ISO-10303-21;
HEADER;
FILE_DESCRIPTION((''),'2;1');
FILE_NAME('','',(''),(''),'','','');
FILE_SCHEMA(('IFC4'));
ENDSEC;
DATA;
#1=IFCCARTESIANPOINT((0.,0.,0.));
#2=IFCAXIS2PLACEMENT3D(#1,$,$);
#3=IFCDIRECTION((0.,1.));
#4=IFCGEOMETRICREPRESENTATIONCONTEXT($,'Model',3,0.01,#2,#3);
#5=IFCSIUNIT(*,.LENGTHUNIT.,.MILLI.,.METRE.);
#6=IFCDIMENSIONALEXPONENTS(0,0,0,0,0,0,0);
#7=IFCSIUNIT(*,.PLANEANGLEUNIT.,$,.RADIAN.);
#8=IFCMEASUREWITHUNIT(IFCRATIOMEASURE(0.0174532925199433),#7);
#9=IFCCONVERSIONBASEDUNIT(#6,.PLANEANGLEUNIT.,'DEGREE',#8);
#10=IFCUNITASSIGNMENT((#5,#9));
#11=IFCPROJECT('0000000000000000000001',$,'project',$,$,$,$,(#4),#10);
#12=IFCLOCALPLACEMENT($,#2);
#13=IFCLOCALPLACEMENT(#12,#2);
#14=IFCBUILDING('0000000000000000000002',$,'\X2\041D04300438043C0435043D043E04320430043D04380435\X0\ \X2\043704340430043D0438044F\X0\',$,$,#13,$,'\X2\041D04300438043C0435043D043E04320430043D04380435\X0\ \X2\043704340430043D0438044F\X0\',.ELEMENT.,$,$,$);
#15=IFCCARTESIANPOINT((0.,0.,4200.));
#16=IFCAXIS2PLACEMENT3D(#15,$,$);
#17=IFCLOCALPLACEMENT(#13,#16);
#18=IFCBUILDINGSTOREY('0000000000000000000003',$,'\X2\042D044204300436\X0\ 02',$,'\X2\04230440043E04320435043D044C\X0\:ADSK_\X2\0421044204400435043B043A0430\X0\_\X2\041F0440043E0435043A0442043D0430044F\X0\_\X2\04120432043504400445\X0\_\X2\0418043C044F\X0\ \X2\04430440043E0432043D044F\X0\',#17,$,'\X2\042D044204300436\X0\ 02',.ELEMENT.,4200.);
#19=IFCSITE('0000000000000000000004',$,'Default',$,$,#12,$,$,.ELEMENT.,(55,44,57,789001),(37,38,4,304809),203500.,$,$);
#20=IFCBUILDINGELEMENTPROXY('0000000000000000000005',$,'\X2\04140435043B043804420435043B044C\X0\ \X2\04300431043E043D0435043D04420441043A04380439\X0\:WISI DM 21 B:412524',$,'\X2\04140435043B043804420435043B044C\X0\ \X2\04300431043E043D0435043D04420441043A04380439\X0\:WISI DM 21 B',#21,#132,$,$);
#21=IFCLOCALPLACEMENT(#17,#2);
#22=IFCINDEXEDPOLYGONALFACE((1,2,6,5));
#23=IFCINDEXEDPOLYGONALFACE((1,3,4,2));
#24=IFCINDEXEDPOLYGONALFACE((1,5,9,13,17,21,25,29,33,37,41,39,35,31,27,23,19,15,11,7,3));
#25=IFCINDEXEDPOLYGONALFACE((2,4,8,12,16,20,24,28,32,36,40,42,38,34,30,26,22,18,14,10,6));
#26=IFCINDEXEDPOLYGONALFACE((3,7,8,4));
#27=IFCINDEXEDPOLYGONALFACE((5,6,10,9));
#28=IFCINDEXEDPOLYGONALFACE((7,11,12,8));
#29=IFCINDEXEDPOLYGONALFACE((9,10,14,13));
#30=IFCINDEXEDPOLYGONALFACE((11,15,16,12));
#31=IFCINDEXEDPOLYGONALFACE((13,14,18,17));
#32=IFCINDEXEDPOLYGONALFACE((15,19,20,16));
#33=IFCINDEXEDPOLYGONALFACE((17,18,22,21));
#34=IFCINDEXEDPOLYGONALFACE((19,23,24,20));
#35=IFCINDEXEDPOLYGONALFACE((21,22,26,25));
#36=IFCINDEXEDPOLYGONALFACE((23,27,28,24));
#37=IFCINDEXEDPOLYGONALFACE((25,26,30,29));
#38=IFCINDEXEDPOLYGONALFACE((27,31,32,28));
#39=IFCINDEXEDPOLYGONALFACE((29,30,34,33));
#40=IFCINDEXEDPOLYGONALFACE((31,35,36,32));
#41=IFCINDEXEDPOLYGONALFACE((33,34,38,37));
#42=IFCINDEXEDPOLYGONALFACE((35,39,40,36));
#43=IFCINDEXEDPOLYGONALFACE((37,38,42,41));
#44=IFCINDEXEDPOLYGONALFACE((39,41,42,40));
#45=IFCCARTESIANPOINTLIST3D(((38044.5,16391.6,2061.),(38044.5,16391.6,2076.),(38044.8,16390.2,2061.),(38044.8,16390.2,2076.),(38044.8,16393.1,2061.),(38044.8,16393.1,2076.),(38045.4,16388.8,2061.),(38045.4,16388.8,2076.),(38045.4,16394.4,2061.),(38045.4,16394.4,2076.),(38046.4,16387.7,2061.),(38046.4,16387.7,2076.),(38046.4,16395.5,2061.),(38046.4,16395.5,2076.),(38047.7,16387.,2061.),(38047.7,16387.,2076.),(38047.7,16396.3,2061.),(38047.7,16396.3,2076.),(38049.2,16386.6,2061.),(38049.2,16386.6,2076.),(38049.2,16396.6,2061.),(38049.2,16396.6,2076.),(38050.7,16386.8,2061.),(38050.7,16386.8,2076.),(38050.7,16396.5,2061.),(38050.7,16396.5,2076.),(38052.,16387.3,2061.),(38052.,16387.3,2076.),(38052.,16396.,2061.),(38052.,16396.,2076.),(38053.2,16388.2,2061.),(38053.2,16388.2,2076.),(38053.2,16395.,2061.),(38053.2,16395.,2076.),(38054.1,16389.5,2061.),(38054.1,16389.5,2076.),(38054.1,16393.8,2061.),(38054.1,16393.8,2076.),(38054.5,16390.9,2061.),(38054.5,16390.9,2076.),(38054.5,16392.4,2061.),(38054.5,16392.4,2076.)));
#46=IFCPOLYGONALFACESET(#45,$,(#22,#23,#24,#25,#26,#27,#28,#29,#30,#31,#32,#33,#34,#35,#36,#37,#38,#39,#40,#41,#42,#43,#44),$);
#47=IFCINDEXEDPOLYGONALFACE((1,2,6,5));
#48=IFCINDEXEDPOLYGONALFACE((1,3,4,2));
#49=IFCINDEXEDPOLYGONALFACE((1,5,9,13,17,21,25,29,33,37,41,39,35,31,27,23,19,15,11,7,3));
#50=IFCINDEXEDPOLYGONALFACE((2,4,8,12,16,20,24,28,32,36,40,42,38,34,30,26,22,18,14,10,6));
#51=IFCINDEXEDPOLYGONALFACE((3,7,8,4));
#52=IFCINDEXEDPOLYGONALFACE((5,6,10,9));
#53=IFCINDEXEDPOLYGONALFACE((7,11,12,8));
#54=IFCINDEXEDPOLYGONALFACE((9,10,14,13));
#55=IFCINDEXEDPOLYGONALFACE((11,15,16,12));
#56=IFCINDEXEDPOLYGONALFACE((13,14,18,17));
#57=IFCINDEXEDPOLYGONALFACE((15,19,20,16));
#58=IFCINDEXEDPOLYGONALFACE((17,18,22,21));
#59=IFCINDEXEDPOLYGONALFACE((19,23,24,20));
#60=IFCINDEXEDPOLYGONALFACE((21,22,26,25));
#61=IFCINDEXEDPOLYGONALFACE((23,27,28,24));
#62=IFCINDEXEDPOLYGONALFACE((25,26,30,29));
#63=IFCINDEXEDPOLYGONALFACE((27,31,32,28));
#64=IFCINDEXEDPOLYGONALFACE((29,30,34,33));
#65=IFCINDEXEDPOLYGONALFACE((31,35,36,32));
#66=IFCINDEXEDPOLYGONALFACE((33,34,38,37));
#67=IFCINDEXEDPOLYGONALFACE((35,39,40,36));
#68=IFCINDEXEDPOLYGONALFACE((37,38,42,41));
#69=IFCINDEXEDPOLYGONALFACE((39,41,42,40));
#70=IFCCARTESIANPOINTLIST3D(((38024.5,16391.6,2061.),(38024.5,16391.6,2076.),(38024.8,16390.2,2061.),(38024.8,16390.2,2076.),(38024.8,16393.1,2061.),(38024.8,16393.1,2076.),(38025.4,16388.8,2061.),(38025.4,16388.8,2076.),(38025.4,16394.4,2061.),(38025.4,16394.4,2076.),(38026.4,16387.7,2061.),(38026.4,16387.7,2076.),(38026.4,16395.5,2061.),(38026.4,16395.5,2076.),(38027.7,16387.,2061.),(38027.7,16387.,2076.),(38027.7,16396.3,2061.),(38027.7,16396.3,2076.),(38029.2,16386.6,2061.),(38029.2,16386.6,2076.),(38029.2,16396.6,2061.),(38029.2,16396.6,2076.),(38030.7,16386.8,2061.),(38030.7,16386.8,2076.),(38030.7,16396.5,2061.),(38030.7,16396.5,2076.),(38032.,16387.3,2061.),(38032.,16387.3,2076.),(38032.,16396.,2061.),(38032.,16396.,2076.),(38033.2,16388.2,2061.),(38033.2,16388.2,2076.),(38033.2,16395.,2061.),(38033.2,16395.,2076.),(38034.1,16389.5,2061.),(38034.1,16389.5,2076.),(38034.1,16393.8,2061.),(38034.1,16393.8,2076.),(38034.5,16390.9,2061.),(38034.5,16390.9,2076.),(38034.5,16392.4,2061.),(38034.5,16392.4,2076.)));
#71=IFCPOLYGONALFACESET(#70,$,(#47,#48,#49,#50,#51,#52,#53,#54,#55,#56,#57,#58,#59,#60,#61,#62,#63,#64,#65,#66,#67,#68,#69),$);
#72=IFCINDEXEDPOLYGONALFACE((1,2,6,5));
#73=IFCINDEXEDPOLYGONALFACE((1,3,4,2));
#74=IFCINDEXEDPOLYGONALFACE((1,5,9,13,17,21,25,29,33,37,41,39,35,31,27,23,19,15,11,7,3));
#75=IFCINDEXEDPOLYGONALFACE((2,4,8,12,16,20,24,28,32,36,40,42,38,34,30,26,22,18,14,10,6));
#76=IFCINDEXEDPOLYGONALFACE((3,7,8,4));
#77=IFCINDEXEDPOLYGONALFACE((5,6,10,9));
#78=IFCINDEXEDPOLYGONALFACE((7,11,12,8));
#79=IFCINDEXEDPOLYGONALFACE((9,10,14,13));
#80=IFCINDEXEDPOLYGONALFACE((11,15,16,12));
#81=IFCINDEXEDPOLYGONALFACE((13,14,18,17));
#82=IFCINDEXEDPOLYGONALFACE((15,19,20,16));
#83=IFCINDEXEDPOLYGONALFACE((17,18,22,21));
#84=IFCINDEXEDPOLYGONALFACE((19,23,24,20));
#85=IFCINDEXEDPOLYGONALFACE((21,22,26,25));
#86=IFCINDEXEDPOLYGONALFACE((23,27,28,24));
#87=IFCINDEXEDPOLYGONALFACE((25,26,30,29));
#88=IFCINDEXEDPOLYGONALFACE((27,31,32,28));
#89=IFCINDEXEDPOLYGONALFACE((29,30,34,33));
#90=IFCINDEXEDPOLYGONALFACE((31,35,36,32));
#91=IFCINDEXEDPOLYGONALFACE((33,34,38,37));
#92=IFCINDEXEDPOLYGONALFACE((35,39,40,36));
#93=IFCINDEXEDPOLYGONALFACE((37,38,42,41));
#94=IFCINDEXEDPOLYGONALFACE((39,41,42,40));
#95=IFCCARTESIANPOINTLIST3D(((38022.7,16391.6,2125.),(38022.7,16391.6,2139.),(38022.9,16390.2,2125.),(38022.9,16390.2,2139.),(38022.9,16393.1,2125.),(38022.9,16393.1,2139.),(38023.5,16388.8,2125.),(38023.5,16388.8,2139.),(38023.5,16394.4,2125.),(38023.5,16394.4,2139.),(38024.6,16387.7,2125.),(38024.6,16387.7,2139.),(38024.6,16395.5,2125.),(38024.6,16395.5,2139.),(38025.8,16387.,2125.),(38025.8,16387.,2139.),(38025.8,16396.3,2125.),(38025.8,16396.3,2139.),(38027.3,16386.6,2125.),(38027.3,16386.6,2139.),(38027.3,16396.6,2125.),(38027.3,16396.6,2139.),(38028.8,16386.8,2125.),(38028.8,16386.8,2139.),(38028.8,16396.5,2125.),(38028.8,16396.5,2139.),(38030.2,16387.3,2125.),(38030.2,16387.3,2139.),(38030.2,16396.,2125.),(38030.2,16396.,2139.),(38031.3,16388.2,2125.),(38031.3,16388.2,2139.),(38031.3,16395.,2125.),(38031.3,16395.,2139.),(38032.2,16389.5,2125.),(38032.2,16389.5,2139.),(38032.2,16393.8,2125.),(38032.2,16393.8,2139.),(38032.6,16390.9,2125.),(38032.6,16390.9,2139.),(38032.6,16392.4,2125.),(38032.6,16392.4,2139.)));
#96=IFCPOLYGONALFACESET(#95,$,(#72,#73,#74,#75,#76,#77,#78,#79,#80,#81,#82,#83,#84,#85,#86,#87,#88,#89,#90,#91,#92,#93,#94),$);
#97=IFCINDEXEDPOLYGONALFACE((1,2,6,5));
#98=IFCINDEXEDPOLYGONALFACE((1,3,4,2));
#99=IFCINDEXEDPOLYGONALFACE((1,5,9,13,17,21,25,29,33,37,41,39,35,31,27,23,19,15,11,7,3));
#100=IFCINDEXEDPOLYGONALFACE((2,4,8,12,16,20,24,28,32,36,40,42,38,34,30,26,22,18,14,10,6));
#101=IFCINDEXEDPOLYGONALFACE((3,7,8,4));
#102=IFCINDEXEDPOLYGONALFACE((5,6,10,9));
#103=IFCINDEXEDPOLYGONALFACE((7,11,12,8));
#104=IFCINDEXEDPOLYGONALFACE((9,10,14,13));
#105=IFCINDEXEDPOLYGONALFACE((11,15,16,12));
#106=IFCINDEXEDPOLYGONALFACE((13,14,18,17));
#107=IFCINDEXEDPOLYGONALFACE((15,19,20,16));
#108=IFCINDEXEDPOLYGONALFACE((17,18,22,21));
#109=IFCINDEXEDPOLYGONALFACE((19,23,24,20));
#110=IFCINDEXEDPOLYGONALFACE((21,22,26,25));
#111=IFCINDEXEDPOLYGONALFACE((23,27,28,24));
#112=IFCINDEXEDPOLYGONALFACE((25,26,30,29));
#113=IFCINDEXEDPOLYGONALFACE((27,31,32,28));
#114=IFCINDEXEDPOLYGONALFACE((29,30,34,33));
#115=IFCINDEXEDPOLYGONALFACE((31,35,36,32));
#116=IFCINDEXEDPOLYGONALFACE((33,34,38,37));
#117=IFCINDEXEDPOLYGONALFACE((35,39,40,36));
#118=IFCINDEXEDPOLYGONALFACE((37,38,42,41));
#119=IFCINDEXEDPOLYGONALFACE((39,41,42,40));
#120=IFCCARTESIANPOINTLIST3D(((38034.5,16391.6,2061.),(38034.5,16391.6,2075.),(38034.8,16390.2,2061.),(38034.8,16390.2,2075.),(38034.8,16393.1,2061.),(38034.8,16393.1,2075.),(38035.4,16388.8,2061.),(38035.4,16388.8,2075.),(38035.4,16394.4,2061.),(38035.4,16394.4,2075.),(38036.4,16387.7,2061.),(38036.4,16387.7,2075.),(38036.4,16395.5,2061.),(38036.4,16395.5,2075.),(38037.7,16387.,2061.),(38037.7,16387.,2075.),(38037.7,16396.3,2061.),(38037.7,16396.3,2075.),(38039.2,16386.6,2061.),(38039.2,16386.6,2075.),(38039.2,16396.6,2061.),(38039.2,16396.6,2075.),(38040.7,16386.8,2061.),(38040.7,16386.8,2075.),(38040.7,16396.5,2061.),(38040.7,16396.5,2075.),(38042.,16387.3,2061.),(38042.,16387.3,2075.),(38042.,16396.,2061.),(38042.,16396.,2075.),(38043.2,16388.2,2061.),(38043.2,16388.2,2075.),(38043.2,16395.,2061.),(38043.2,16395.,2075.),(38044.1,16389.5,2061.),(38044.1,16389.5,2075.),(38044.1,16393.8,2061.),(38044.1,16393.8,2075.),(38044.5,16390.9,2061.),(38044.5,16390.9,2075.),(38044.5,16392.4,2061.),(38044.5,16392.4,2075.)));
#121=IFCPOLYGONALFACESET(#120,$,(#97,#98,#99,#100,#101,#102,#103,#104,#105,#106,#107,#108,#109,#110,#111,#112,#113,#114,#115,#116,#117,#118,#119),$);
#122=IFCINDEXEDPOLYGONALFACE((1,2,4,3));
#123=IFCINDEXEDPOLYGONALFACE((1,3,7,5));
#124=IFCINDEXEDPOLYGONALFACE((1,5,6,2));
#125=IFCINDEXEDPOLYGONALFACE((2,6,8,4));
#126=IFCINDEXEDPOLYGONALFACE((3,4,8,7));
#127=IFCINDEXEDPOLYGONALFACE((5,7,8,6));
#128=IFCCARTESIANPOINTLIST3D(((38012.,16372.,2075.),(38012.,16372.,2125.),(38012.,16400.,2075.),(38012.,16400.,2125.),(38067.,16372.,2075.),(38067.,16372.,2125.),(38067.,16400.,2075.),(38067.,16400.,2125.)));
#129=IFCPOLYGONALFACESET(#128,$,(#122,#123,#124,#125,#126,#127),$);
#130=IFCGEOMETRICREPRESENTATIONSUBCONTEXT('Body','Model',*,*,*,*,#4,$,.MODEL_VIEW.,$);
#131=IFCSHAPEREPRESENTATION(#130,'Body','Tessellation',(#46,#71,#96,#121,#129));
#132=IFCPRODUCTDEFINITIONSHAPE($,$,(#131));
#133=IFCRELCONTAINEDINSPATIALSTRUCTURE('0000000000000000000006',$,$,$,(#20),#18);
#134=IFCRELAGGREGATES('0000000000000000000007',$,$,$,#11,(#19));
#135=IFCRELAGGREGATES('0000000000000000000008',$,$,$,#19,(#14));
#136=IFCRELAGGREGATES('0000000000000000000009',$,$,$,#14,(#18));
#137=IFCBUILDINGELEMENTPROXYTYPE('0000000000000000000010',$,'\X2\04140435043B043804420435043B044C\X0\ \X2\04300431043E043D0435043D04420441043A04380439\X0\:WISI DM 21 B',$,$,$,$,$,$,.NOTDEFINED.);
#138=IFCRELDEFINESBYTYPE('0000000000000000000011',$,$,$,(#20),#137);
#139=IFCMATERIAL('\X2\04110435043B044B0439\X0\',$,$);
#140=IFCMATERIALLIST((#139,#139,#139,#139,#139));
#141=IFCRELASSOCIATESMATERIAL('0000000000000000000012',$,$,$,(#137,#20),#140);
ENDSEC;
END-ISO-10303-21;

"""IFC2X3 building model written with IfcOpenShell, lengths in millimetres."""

from ifc_helpers import new_model, entity, si_unit, converted_unit, direction, frame, origin, origin_2d_with_axis, place, context, subcontext, project, spatial, rectangle, circle, extrude, source, transform, mapped, material, material_list, type_object, type_shapes, element, save


model = new_model("IFC2X3")

# Units and contexts
model_context = context("Model", 3, precision=0.01, world=origin(), true_north=direction((0.0, 1.0)))
body_context = subcontext(model_context, "Body", "Model", "MODEL_VIEW")
ifc_project = project(units=[si_unit("LENGTHUNIT", "METRE", prefix="MILLI"), converted_unit("PLANEANGLEUNIT", "DEGREE", entity("IfcRatioMeasure", 0.0174532925199433), si_unit("PLANEANGLEUNIT", "RADIAN"), dimensions=[0, 0, 0, 0, 0, 0, 0])], contexts=[model_context])

# Site, building, storey
site_placement = place(None, origin())
site = spatial("IfcSite", under=ifc_project, at=site_placement, Name="Default", CompositionType="ELEMENT", RefLatitude=(55, 44, 57, 789001), RefLongitude=(37, 38, 4, 304809), RefElevation=203500.0)
building_placement = place(site_placement, origin())
building = spatial("IfcBuilding", under=site, at=building_placement, Name="Наименование здания", LongName="Наименование здания", CompositionType="ELEMENT")
storey_placement = place(building_placement, frame((0.0, 0.0, 4200.0)))
storey = spatial("IfcBuildingStorey", under=building, at=storey_placement, Name="Этаж 02", ObjectType="Уровень:ADSK_Стрелка_Проектная_Вверх_Имя уровня", LongName="Этаж 02", CompositionType="ELEMENT", Elevation=4200.0)

# Building element proxy
ifc_material_1 = material(Name="Белый")
ifc_material_list_1 = material_list([ifc_material_1, ifc_material_1, ifc_material_1, ifc_material_1, ifc_material_1])
shared_shape_1 = source(origin(), body_context, "Body", "SweptSolid", [
    extrude(circle(Radius=5.0, at=origin_2d_with_axis()), frame((10.0, -39.0, 8.4), z_axis=(0.0, 1.0, 0.0), x_axis=(-1.0, 0.0, 0.0)), (0.0, 0.0, 1.0), 15.0),
    extrude(circle(Radius=5.0, at=origin_2d_with_axis()), frame((-10.0, -39.0, 8.4), z_axis=(0.0, 1.0, 0.0), x_axis=(-1.0, 0.0, 0.0)), (0.0, 0.0, 1.0), 15.0),
    extrude(circle(Radius=5.0, at=origin_2d_with_axis()), frame((-11.8, 25.0, 8.4), z_axis=(0.0, 1.0, 0.0), x_axis=(-1.0, 0.0, 0.0)), (0.0, 0.0, 1.0), 14.0),
    extrude(circle(Radius=5.0, at=origin_2d_with_axis()), frame((0.0, -39.0, 8.4), z_axis=(0.0, 1.0, 0.0), x_axis=(-1.0, 0.0, 0.0)), (0.0, 0.0, 1.0), 14.0),
    extrude(rectangle(XDim=55.0, YDim=50.0, at=origin_2d_with_axis()), frame((0.0, 0.0, 0.0), z_axis=(0.0, 0.0, 1.0), x_axis=(-1.0, 0.0, 0.0)), (0.0, 0.0, 1.0), 28.0),
])
building_element_proxy_type_1 = type_object("IfcBuildingElementProxyType", Name="Делитель абонентский:WISI DM 21 B", PredefinedType="NOTDEFINED", material=ifc_material_list_1)
type_shapes(building_element_proxy_type_1, [shared_shape_1])
proxy_1_placement = place(storey_placement, frame((38039.5, 16400.0, 2100.0), z_axis=(0.0, -1.0, 0.0), x_axis=(1.0, 0.0, 0.0)))
element("IfcBuildingElementProxy", 1, at=proxy_1_placement, inside=storey, type_object=building_element_proxy_type_1, material=ifc_material_list_1, Name="Делитель абонентский:WISI DM 21 B:412524", ObjectType="Делитель абонентский:WISI DM 21 B", context=body_context, shape_type="MappedRepresentation", body=[
    mapped(shared_shape_1, transform((0.0, 0.0, 0.0), scale=1.0)),
])

save(model, "model.ifc")
